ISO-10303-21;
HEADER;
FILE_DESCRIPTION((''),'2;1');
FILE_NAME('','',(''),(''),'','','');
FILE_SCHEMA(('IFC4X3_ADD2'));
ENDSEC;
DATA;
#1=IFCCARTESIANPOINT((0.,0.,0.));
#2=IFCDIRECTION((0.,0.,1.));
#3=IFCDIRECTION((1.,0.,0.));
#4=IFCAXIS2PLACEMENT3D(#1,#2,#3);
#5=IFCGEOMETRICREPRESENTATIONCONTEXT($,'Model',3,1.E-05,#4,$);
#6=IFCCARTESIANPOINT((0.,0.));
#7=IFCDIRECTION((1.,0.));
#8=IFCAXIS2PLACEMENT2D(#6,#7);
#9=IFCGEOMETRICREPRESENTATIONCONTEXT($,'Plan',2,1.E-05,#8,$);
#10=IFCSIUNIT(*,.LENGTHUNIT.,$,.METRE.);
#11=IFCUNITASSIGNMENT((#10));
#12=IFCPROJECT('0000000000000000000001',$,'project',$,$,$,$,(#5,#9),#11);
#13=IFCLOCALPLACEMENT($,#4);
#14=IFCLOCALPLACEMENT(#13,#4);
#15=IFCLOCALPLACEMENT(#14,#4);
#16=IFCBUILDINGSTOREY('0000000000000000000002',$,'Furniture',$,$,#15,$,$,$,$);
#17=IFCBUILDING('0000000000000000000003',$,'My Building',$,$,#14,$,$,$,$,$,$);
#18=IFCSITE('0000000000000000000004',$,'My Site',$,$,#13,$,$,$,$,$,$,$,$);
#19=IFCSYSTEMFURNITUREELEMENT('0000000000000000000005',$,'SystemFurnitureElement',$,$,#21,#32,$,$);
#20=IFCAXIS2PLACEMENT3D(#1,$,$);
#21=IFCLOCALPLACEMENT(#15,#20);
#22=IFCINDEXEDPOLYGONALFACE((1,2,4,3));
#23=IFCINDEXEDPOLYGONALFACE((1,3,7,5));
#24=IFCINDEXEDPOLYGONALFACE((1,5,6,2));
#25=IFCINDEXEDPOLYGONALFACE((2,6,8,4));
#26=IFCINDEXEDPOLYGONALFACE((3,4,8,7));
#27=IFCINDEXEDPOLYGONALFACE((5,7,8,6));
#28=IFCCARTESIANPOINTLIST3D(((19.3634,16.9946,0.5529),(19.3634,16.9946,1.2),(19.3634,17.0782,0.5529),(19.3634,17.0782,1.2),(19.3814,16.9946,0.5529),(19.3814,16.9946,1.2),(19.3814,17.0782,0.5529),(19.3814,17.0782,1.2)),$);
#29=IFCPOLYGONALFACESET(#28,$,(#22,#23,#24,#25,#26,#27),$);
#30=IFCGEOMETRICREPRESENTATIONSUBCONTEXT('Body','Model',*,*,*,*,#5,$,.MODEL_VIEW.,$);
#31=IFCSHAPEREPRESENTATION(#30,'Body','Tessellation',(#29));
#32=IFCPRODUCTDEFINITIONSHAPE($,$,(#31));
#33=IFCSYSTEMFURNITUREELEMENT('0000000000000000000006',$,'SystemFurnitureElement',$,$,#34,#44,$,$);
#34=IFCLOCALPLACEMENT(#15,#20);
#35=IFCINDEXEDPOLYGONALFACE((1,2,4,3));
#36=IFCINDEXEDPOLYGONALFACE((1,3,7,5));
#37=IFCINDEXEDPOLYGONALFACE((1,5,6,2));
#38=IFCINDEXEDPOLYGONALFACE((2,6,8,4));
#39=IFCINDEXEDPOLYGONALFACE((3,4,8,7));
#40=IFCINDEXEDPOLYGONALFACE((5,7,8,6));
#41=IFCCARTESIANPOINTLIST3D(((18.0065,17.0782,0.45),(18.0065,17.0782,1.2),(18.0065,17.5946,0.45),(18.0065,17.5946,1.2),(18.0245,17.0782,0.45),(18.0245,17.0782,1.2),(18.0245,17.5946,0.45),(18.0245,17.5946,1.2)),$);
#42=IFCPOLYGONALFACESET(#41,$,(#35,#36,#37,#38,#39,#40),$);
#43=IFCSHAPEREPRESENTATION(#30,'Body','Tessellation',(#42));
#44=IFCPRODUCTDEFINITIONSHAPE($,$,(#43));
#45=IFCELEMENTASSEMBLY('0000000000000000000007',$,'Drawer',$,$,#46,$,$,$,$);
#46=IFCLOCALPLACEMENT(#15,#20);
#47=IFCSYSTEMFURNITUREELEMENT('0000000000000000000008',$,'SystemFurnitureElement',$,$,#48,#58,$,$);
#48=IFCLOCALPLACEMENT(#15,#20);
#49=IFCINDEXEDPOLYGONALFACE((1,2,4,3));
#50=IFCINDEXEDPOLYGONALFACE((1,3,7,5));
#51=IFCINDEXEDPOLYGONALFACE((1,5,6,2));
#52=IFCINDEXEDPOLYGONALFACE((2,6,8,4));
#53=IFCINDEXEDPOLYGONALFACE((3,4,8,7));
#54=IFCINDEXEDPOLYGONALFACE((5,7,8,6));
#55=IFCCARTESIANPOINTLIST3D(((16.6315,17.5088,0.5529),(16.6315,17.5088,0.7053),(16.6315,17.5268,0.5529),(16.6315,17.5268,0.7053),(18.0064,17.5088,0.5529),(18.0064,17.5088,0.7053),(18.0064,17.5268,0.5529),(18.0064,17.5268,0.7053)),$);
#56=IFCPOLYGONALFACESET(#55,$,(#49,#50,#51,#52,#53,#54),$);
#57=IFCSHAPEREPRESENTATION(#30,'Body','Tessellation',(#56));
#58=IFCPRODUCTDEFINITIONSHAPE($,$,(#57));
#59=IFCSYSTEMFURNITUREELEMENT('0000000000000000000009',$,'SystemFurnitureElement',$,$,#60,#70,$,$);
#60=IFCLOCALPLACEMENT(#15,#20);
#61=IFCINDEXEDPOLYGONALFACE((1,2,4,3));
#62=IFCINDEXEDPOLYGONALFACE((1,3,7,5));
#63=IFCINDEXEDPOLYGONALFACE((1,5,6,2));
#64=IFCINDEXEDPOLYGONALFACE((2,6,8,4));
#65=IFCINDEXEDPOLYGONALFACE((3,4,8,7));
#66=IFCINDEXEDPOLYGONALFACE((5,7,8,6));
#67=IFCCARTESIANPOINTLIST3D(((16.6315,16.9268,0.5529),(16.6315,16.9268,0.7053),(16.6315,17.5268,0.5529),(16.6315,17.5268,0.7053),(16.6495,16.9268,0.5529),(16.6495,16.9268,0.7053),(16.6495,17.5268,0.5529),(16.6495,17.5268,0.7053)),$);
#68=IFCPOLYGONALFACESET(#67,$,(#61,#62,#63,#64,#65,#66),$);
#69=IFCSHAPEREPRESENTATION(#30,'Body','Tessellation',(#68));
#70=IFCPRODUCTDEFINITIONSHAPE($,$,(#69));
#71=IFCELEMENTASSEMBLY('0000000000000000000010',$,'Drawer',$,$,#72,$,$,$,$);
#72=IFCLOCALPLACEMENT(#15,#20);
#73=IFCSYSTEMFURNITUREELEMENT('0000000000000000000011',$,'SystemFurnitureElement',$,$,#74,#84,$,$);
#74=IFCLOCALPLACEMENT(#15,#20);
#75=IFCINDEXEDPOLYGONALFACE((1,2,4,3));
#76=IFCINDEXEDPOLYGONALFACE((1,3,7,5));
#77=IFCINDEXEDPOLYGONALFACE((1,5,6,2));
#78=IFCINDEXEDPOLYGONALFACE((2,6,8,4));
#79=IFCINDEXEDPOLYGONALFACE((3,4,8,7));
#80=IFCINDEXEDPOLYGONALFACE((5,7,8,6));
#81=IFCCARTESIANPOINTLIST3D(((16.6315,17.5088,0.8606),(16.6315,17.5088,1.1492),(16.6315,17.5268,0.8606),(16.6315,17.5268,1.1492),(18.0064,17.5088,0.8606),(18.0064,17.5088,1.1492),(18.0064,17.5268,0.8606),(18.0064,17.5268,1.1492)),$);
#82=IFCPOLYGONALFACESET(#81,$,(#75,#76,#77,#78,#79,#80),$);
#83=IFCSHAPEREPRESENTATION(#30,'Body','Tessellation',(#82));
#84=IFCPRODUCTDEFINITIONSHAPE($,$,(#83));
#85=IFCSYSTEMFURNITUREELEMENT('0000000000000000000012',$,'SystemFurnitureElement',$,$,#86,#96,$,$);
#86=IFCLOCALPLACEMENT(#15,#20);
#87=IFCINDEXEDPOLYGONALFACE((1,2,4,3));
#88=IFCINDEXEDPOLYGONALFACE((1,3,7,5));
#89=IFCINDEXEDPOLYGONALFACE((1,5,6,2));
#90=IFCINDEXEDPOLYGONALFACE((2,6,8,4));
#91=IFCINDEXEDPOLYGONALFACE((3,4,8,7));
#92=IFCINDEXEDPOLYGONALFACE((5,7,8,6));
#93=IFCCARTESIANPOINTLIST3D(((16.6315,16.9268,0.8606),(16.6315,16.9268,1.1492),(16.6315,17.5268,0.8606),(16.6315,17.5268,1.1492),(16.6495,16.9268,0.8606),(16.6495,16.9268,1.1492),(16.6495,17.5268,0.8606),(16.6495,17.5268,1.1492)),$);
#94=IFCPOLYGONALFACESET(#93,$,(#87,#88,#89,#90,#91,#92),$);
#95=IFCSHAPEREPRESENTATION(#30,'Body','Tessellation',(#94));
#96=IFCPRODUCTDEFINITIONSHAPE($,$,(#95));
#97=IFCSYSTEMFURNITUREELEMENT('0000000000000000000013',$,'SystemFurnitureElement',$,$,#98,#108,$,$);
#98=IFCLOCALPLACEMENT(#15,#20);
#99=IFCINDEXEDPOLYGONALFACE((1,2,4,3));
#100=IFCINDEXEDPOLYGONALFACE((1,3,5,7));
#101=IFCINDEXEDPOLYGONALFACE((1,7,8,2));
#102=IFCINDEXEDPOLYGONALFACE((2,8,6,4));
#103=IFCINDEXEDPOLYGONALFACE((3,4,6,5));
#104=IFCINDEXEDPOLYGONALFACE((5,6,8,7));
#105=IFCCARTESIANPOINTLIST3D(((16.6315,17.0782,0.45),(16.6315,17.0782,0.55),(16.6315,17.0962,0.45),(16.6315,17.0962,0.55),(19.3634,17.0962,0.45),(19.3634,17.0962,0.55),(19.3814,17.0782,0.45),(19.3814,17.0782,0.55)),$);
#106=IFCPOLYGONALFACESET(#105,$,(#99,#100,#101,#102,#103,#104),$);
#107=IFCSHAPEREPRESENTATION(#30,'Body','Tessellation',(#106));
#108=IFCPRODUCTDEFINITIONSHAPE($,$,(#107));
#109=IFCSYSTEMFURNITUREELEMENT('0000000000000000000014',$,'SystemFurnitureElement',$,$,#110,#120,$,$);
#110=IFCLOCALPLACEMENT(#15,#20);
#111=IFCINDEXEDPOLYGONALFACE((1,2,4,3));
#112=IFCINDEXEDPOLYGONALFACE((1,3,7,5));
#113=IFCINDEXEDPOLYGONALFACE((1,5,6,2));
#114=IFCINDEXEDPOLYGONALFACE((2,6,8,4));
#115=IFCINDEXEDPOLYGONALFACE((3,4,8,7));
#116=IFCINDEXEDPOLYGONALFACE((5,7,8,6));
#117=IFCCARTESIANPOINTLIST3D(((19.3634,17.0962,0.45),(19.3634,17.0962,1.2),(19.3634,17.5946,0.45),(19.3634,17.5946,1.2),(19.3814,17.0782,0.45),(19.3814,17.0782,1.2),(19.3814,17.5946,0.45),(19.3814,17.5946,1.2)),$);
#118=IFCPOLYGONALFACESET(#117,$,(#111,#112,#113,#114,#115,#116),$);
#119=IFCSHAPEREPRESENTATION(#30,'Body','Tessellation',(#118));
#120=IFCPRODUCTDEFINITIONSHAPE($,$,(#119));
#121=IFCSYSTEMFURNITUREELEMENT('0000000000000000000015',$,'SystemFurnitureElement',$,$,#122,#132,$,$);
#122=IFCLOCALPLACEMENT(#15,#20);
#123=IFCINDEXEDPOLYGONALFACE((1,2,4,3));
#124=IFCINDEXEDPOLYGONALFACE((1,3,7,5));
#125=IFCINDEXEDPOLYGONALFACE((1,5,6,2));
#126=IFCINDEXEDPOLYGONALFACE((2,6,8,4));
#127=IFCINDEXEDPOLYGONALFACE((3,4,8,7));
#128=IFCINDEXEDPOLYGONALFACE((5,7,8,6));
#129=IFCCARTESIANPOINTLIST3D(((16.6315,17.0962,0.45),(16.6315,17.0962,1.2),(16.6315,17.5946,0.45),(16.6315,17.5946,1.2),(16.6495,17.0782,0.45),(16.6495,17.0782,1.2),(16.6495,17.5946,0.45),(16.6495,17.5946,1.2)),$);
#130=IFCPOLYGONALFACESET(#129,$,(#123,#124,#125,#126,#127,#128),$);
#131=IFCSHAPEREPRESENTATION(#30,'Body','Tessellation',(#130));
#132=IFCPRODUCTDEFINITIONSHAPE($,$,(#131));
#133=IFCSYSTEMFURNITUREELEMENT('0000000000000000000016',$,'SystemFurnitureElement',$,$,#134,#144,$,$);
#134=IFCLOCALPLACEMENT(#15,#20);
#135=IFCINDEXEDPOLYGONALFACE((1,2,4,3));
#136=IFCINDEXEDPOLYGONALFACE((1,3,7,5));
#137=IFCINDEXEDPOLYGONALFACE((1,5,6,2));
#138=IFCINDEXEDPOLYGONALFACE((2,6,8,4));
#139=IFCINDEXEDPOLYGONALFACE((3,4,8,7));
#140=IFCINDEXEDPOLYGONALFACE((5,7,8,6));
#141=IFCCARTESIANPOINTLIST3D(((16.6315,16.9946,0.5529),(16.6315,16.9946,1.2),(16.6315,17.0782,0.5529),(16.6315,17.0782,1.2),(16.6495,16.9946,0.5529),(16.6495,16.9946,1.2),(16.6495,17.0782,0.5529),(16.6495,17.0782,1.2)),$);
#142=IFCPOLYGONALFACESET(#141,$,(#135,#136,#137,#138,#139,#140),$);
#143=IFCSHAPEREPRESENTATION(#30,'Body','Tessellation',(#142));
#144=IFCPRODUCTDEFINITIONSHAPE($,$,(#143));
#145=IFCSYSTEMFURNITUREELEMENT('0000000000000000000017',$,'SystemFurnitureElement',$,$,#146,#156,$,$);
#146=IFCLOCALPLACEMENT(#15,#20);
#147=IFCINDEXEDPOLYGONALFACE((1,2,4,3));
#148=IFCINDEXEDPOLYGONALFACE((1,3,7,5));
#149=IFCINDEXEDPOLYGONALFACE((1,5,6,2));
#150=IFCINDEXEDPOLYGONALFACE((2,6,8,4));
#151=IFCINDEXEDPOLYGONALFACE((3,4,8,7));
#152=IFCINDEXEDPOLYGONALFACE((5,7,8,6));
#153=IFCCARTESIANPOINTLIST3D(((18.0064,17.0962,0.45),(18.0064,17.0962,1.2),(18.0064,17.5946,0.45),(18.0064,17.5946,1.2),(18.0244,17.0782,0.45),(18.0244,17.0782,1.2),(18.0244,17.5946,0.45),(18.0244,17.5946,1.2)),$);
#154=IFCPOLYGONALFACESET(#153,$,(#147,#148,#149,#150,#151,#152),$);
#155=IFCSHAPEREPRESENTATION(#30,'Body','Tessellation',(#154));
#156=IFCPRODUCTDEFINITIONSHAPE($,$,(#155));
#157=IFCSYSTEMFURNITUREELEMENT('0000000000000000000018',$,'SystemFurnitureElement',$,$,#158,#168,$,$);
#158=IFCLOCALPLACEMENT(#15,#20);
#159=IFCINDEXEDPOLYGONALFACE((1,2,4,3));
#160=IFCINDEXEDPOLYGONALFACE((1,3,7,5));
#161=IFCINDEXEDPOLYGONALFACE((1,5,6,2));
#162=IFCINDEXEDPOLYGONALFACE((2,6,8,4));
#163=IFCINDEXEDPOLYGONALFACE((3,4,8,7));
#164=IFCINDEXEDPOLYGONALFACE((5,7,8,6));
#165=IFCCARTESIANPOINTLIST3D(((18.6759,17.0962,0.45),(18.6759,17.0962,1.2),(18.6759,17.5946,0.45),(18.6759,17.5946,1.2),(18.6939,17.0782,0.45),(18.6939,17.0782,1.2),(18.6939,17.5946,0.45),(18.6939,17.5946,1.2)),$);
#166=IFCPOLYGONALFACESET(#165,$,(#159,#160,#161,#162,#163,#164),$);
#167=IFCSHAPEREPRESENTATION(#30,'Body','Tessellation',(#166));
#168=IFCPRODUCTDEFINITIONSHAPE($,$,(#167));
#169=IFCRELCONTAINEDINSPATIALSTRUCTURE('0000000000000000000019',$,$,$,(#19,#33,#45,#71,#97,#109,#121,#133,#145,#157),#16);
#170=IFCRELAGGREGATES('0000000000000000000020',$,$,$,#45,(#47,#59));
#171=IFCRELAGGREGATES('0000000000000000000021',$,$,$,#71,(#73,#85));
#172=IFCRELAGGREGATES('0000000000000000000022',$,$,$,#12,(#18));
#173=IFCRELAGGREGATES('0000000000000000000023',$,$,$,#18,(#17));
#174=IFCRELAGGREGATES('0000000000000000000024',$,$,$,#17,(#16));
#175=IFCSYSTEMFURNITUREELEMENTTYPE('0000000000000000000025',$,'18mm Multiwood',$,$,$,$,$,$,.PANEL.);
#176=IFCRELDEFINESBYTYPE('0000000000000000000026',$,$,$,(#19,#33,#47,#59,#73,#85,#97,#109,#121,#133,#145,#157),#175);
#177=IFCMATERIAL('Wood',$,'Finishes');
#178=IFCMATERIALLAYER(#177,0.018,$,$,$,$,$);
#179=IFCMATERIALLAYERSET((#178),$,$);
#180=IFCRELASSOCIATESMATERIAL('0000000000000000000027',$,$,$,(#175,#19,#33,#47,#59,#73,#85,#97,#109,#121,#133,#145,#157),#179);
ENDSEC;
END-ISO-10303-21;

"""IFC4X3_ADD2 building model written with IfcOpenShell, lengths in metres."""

from ifc_helpers import new_model, si_unit, frame, origin_with_axes, origin_2d_with_axis, place, context, subcontext, project, spatial, line, indexed_curve, outline, extrude, material, layer, layer_set, layer_usage, type_object, element, aggregate, save


model = new_model("IFC4X3_ADD2")

# Units and contexts
model_context = context("Model", 3, precision=1e-05, world=origin_with_axes())
plan_context = context("Plan", 2, precision=1e-05, world=origin_2d_with_axis())
body_context = subcontext(model_context, "Body", "Model", "MODEL_VIEW")
ifc_project = project(units=[si_unit("LENGTHUNIT", "METRE")], contexts=[model_context, plan_context])

# Site, building, storey
site_placement = place(None, origin_with_axes())
site = spatial("IfcSite", under=ifc_project, at=site_placement, Name="My Site")
building_placement = place(site_placement, origin_with_axes())
building = spatial("IfcBuilding", under=site, at=building_placement, Name="My Building")
storey_placement = place(building_placement, origin_with_axes())
storey = spatial("IfcBuildingStorey", under=building, at=storey_placement, Name="Furniture")

# System furniture elements
ifc_material_1 = material(Name="Wood", Category="Finishes")
ifc_layer_1 = layer(ifc_material_1, 0.018)
ifc_layer_set_1 = layer_set([ifc_layer_1])
ifc_layer_usage_1 = layer_usage(ifc_layer_set_1, "AXIS2", "POSITIVE", 0.0)
system_furniture_element_type_1 = type_object("IfcSystemFurnitureElementType", Name="18mm Multiwood", PredefinedType="PANEL", material=ifc_layer_set_1)
system_furniture_element_1_placement = place(storey_placement, frame((19.3814, 16.9946, 0.5529), z_axis=(0.0, 0.0, 1.0), x_axis=(0.0, 1.0, 0.0)))
element("IfcSystemFurnitureElement", 1, at=system_furniture_element_1_placement, inside=storey, type_object=system_furniture_element_type_1, material=ifc_layer_usage_1, Name="SystemFurnitureElement", context=body_context, shape_type="SweptSolid", body=[
    extrude(outline(indexed_curve([(0.0, 0.0), (0.0, 0.018), (0.0836, 0.018), (0.0836, 0.0)], segments=[line(1, 2, 3, 4, 1)])), origin_with_axes(), (0.0, 0.0, 1.0), 0.6471),
])
ifc_layer_usage_2 = layer_usage(ifc_layer_set_1, "AXIS2", "POSITIVE", 0.0)
system_furniture_element_2_placement = place(storey_placement, frame((18.0245, 17.0782, 0.45), z_axis=(0.0, 0.0, 1.0), x_axis=(0.0, 1.0, 0.0)))
element("IfcSystemFurnitureElement", 2, at=system_furniture_element_2_placement, inside=storey, type_object=system_furniture_element_type_1, material=ifc_layer_usage_2, Name="SystemFurnitureElement", context=body_context, shape_type="SweptSolid", body=[
    extrude(outline(indexed_curve([(0.0, 0.0), (0.0, 0.018), (0.5164, 0.018), (0.5164, 0.0)], segments=[line(1, 2, 3, 4, 1)])), origin_with_axes(), (0.0, 0.0, 1.0), 0.75),
])

# Element assemblies, system furniture elements
assembly_1_placement = place(storey_placement, frame((16.6315, 16.9088, 0.5529), z_axis=(0.0, 0.0, 1.0), x_axis=(-1.0, 0.0, 0.0)))
assembly_1 = element("IfcElementAssembly", 3, at=assembly_1_placement, inside=storey, Name="Drawer")
ifc_layer_usage_3 = layer_usage(ifc_layer_set_1, "AXIS2", "POSITIVE", 0.0)
system_furniture_element_3_placement = place(assembly_1_placement, frame((-1.375, -0.618, 0.0), z_axis=(0.0, 0.0, 1.0), x_axis=(1.0, 0.0, 0.0)))
system_furniture_element_3 = element("IfcSystemFurnitureElement", 4, at=system_furniture_element_3_placement, type_object=system_furniture_element_type_1, material=ifc_layer_usage_3, Name="SystemFurnitureElement", context=body_context, shape_type="SweptSolid", body=[
    extrude(outline(indexed_curve([(0.0, 0.0), (0.0, 0.018), (1.375, 0.018), (1.375, 0.0)], segments=[line(1, 2, 3, 4, 1)])), origin_with_axes(), (0.0, 0.0, 1.0), 0.1524),
])
ifc_layer_usage_4 = layer_usage(ifc_layer_set_1, "AXIS2", "POSITIVE", 0.0)
system_furniture_element_4_placement = place(assembly_1_placement, frame((-0.018, -0.018, 0.0), z_axis=(0.0, 0.0, 1.0), x_axis=(-0.000001, -1.0, 0.0)))
system_furniture_element_4 = element("IfcSystemFurnitureElement", 5, at=system_furniture_element_4_placement, type_object=system_furniture_element_type_1, material=ifc_layer_usage_4, Name="SystemFurnitureElement", context=body_context, shape_type="SweptSolid", body=[
    extrude(outline(indexed_curve([(0.0, 0.0), (0.0, 0.018), (0.6, 0.018), (0.6, 0.0)], segments=[line(1, 2, 3, 4, 1)])), origin_with_axes(), (0.0, 0.0, 1.0), 0.1524),
])
assembly_2_placement = place(storey_placement, frame((16.6315, 16.9088, 0.8606), z_axis=(0.0, 0.0, 1.0), x_axis=(-1.0, 0.0, 0.0)))
assembly_2 = element("IfcElementAssembly", 6, at=assembly_2_placement, inside=storey, Name="Drawer")
ifc_layer_usage_5 = layer_usage(ifc_layer_set_1, "AXIS2", "POSITIVE", 0.0)
system_furniture_element_5_placement = place(assembly_2_placement, frame((-1.375, -0.618, 0.0), z_axis=(0.0, 0.0, 1.0), x_axis=(1.0, 0.0, 0.0)))
system_furniture_element_5 = element("IfcSystemFurnitureElement", 7, at=system_furniture_element_5_placement, type_object=system_furniture_element_type_1, material=ifc_layer_usage_5, Name="SystemFurnitureElement", context=body_context, shape_type="SweptSolid", body=[
    extrude(outline(indexed_curve([(0.0, 0.0), (0.0, 0.018), (1.375, 0.018), (1.375, 0.0)], segments=[line(1, 2, 3, 4, 1)])), origin_with_axes(), (0.0, 0.0, 1.0), 0.2886),
])
ifc_layer_usage_6 = layer_usage(ifc_layer_set_1, "AXIS2", "POSITIVE", 0.0)
system_furniture_element_6_placement = place(assembly_2_placement, frame((-0.018, -0.018, 0.0), z_axis=(0.0, 0.0, 1.0), x_axis=(-0.000001, -1.0, 0.0)))
system_furniture_element_6 = element("IfcSystemFurnitureElement", 8, at=system_furniture_element_6_placement, type_object=system_furniture_element_type_1, material=ifc_layer_usage_6, Name="SystemFurnitureElement", context=body_context, shape_type="SweptSolid", body=[
    extrude(outline(indexed_curve([(0.0, 0.0), (0.0, 0.018), (0.6, 0.018), (0.6, 0.0)], segments=[line(1, 2, 3, 4, 1)])), origin_with_axes(), (0.0, 0.0, 1.0), 0.2886),
])

# System furniture elements
ifc_layer_usage_7 = layer_usage(ifc_layer_set_1, "AXIS2", "POSITIVE", 0.0)
system_furniture_element_7_placement = place(storey_placement, frame((19.3814, 17.0962, 0.45), z_axis=(0.0, 0.0, 1.0), x_axis=(-1.0, 0.000001, 0.0)))
element("IfcSystemFurnitureElement", 9, at=system_furniture_element_7_placement, inside=storey, type_object=system_furniture_element_type_1, material=ifc_layer_usage_7, Name="SystemFurnitureElement", context=body_context, shape_type="SweptSolid", body=[
    extrude(outline(indexed_curve([(0.018, 0.0), (0.0, 0.018), (2.75, 0.018), (2.75, 0.0)], segments=[line(1, 2, 3, 4, 1)])), origin_with_axes(), (0.0, 0.0, 1.0), 0.1),
])
ifc_layer_usage_8 = layer_usage(ifc_layer_set_1, "AXIS2", "POSITIVE", 0.0)
system_furniture_element_8_placement = place(storey_placement, frame((19.3814, 17.0962, 0.45), z_axis=(0.0, 0.0, 1.0), x_axis=(0.0, 1.0, 0.0)))
element("IfcSystemFurnitureElement", 10, at=system_furniture_element_8_placement, inside=storey, type_object=system_furniture_element_type_1, material=ifc_layer_usage_8, Name="SystemFurnitureElement", context=body_context, shape_type="SweptSolid", body=[
    extrude(outline(indexed_curve([(-0.018, 0.0), (0.0, 0.018), (0.4984, 0.018), (0.4984, 0.0)], segments=[line(1, 2, 3, 4, 1)])), origin_with_axes(), (0.0, 0.0, 1.0), 0.75),
])
ifc_layer_usage_9 = layer_usage(ifc_layer_set_1, "AXIS2", "POSITIVE", 0.0)
system_furniture_element_9_placement = place(storey_placement, frame((16.6495, 17.0962, 0.45), z_axis=(0.0, 0.0, 1.0), x_axis=(0.0, 1.0, 0.0)))
element("IfcSystemFurnitureElement", 11, at=system_furniture_element_9_placement, inside=storey, type_object=system_furniture_element_type_1, material=ifc_layer_usage_9, Name="SystemFurnitureElement", context=body_context, shape_type="SweptSolid", body=[
    extrude(outline(indexed_curve([(-0.018, 0.0), (0.0, 0.018), (0.4984, 0.018), (0.4984, 0.0)], segments=[line(1, 2, 3, 4, 1)])), origin_with_axes(), (0.0, 0.0, 1.0), 0.75),
])
ifc_layer_usage_10 = layer_usage(ifc_layer_set_1, "AXIS2", "POSITIVE", 0.0)
system_furniture_element_10_placement = place(storey_placement, frame((16.6495, 16.9946, 0.5529), z_axis=(0.0, 0.0, 1.0), x_axis=(0.0, 1.0, 0.0)))
element("IfcSystemFurnitureElement", 12, at=system_furniture_element_10_placement, inside=storey, type_object=system_furniture_element_type_1, material=ifc_layer_usage_10, Name="SystemFurnitureElement", context=body_context, shape_type="SweptSolid", body=[
    extrude(outline(indexed_curve([(0.0, 0.0), (0.0, 0.018), (0.0836, 0.018), (0.0836, 0.0)], segments=[line(1, 2, 3, 4, 1)])), origin_with_axes(), (0.0, 0.0, 1.0), 0.6471),
])
ifc_layer_usage_11 = layer_usage(ifc_layer_set_1, "AXIS2", "POSITIVE", 0.0)
system_furniture_element_11_placement = place(storey_placement, frame((18.0244, 17.0962, 0.45), z_axis=(0.0, 0.0, 1.0), x_axis=(0.000001, 1.0, 0.0)))
element("IfcSystemFurnitureElement", 13, at=system_furniture_element_11_placement, inside=storey, type_object=system_furniture_element_type_1, material=ifc_layer_usage_11, Name="SystemFurnitureElement", context=body_context, shape_type="SweptSolid", body=[
    extrude(outline(indexed_curve([(-0.018, 0.0), (0.0, 0.018), (0.4984, 0.018), (0.4984, 0.0)], segments=[line(1, 2, 3, 4, 1)])), origin_with_axes(), (0.0, 0.0, 1.0), 0.75),
])
ifc_layer_usage_12 = layer_usage(ifc_layer_set_1, "AXIS2", "POSITIVE", 0.0)
system_furniture_element_12_placement = place(storey_placement, frame((18.6939, 17.0962, 0.45), z_axis=(0.0, 0.0, 1.0), x_axis=(0.000001, 1.0, 0.0)))
element("IfcSystemFurnitureElement", 14, at=system_furniture_element_12_placement, inside=storey, type_object=system_furniture_element_type_1, material=ifc_layer_usage_12, Name="SystemFurnitureElement", context=body_context, shape_type="SweptSolid", body=[
    extrude(outline(indexed_curve([(-0.018, 0.0), (0.0, 0.018), (0.4984, 0.018), (0.4984, 0.0)], segments=[line(1, 2, 3, 4, 1)])), origin_with_axes(), (0.0, 0.0, 1.0), 0.75),
])

aggregate(assembly_1, [system_furniture_element_3, system_furniture_element_4])
aggregate(assembly_2, [system_furniture_element_5, system_furniture_element_6])

save(model, "model.ifc")
